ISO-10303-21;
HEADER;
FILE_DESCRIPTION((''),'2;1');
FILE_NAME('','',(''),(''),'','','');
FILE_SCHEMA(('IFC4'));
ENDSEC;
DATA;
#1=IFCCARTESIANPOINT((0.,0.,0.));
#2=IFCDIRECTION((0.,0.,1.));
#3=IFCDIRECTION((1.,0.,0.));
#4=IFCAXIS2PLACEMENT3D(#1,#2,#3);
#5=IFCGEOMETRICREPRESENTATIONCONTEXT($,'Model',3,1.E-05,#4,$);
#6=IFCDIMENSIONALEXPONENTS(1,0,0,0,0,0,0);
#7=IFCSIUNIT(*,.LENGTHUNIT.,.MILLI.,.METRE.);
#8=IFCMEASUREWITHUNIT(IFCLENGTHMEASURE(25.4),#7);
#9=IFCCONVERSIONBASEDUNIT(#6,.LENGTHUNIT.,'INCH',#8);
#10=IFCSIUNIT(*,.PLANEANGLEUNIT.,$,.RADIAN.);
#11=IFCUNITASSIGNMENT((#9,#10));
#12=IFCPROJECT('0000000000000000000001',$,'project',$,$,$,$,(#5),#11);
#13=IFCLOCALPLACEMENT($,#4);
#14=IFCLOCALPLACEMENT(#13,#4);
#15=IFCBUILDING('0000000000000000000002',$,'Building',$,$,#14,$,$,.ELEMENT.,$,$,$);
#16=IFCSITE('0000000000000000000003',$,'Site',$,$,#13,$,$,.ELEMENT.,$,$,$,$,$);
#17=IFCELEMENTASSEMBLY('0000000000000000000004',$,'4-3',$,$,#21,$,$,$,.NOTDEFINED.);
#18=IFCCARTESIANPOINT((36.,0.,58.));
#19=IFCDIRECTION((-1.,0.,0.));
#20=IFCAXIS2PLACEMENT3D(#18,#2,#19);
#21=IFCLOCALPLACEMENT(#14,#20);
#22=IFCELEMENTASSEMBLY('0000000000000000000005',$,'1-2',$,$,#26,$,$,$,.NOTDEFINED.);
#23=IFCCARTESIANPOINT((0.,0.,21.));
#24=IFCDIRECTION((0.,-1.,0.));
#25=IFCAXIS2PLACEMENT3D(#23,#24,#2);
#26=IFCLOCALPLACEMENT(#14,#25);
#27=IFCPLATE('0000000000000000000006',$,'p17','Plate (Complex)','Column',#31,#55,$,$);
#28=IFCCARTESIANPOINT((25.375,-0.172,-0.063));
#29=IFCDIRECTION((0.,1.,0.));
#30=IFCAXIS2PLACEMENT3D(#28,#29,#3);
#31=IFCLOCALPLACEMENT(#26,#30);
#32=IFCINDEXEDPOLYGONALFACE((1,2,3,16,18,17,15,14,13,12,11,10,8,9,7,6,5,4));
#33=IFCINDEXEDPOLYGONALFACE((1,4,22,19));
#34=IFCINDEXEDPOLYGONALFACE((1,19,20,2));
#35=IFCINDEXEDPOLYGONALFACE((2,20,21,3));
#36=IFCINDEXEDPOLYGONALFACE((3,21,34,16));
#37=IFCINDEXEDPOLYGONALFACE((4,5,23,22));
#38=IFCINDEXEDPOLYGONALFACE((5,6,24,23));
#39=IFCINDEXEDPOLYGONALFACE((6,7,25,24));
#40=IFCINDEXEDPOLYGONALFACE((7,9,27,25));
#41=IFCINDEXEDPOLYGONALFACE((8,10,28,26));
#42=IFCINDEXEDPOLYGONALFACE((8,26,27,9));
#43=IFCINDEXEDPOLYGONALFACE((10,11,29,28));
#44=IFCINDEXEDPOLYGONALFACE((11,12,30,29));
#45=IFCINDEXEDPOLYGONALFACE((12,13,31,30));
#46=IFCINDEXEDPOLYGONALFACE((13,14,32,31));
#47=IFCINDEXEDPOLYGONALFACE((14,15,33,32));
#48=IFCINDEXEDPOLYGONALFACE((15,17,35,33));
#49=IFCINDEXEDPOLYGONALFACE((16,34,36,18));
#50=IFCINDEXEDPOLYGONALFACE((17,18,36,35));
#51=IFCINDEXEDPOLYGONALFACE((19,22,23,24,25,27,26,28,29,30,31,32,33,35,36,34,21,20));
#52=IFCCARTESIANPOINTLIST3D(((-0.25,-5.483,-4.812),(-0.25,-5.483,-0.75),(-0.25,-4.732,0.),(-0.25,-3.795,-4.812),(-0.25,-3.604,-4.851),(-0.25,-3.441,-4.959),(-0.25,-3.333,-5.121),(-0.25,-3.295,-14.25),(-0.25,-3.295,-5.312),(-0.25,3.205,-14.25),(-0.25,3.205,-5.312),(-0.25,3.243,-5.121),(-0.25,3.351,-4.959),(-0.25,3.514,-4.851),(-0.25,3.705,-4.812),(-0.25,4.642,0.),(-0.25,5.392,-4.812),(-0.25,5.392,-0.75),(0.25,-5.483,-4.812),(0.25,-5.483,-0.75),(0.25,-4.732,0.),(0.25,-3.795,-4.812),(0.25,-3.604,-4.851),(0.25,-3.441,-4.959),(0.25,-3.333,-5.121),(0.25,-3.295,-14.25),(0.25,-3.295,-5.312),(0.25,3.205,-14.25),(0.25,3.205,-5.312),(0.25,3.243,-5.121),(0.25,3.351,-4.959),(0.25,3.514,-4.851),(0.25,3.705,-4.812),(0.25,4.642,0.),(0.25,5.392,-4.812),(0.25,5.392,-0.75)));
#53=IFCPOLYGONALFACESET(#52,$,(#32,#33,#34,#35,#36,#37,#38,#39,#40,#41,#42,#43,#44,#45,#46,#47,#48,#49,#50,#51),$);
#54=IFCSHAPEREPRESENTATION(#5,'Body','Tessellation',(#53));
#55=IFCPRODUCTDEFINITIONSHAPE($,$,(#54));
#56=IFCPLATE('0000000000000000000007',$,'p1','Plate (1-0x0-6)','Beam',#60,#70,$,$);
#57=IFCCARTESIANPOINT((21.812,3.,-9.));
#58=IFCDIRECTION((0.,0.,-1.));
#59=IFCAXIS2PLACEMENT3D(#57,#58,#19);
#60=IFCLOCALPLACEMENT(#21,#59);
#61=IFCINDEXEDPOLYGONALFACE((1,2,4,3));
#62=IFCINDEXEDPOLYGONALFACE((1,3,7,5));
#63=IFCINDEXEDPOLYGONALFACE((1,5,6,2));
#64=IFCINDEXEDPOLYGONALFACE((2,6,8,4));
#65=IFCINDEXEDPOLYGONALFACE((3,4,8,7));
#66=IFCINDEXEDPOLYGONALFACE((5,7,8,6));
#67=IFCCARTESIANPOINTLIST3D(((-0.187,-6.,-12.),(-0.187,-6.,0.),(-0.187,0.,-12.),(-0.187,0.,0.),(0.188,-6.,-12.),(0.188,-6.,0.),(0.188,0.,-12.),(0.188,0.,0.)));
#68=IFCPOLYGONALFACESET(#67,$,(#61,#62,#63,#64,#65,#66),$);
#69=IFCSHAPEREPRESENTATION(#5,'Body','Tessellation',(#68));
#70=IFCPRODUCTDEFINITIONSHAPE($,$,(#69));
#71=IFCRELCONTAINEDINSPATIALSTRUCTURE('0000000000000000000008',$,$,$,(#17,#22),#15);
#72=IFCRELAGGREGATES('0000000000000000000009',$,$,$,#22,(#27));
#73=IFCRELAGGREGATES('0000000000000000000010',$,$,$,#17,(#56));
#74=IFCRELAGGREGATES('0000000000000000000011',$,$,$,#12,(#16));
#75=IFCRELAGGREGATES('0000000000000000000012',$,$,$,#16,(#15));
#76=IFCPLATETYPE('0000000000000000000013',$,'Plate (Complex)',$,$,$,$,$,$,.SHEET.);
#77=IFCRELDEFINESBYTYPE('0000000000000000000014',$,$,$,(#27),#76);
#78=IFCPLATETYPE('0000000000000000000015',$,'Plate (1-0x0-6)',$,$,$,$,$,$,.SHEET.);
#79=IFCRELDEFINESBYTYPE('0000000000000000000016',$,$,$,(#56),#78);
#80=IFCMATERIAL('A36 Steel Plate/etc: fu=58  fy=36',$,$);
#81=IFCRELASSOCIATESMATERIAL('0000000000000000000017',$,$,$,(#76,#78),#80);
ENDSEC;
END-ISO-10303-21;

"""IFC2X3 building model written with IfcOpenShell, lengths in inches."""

from ifc_helpers import new_model, entity, si_unit, converted_unit, frame, origin_with_axes, place, context, project, spatial, polyline, outline, extrude, source, transform, mapped, material, type_object, type_shapes, element, aggregate, save


model = new_model("IFC2X3")

# Units and contexts
model_context = context("Model", 3, precision=1e-05, world=origin_with_axes())
ifc_project = project(units=[converted_unit("LENGTHUNIT", "INCH", entity("IfcLengthMeasure", 25.4), si_unit("LENGTHUNIT", "METRE", prefix="MILLI"), dimensions=[1, 0, 0, 0, 0, 0, 0]), si_unit("PLANEANGLEUNIT", "RADIAN")], contexts=[model_context])

# Site, building
site_placement = place(None, origin_with_axes())
site = spatial("IfcSite", under=ifc_project, at=site_placement, Name="Site", CompositionType="ELEMENT")
building_placement = place(site_placement, origin_with_axes())
building = spatial("IfcBuilding", under=site, at=building_placement, Name="Building", CompositionType="ELEMENT")

# Element assembly
assembly_1_placement = place(building_placement, frame((36.0, 0.0, 58.0), z_axis=(0.0, 0.0, 1.0), x_axis=(-1.0, 0.0, 0.0)))
assembly_1 = element("IfcElementAssembly", 1, at=assembly_1_placement, inside=building, Name="4-3", PredefinedType="NOTDEFINED")

# Element assembly, plate
assembly_2_placement = place(building_placement, frame((0.0, 0.0, 21.0), z_axis=(0.0, -1.0, 0.0), x_axis=(0.0, 0.0, 1.0)))
assembly_2 = element("IfcElementAssembly", 2, at=assembly_2_placement, inside=building, Name="1-2", PredefinedType="NOTDEFINED")
ifc_material_1 = material(Name="A36 Steel Plate/etc: fu=58  fy=36")
plate_type_1 = type_object("IfcPlateType", Name="Plate (Complex)", PredefinedType="SHEET", material=ifc_material_1)
shared_shape_1 = source(origin_with_axes(), model_context, "Body", "SweptSolid", [
    extrude(outline(polyline([(5.393, -4.812), (3.705, -4.812), (3.514, -4.851), (3.351, -4.959), (3.243, -5.121), (3.205, -5.312), (3.205, -14.25), (-3.295, -14.25), (-3.295, -5.312), (-3.333, -5.121), (-3.441, -4.959), (-3.604, -4.851), (-3.795, -4.812), (-5.482, -4.812), (-5.482, -0.75), (-4.732, 0.0), (4.643, 0.0), (5.393, -0.75), (5.393, -4.812)])), frame((-0.25, 0.0, 0.0), z_axis=(1.0, 0.0, 0.0), x_axis=(0.0, 1.0, 0.0)), (0.0, 0.0, 1.0), 0.5),
])
type_shapes(plate_type_1, [shared_shape_1])
plate_1_placement = place(assembly_2_placement, frame((25.375, -0.172, -0.063), z_axis=(0.0, 1.0, 0.0), x_axis=(1.0, 0.0, 0.0)))
plate_1 = element("IfcPlate", 3, at=plate_1_placement, type_object=plate_type_1, Name="p17", Description="Plate (Complex)", ObjectType="Column", context=model_context, shape_type="MappedRepresentation", body=[
    mapped(shared_shape_1, transform((0.0, 0.0, 0.0), scale=1.0)),
])
aggregate(assembly_2, [plate_1])

# Plate
plate_type_2 = type_object("IfcPlateType", Name="Plate (1-0x0-6)", PredefinedType="SHEET", material=ifc_material_1)
shared_shape_2 = source(origin_with_axes(), model_context, "Body", "SweptSolid", [
    extrude(outline(polyline([(0.0, -12.0), (-6.0, -12.0), (-6.0, 0.0), (0.0, 0.0), (0.0, -12.0)])), frame((-0.188, 0.0, 0.0), z_axis=(1.0, 0.0, 0.0), x_axis=(0.0, 1.0, 0.0)), (0.0, 0.0, 1.0), 0.375),
])
type_shapes(plate_type_2, [shared_shape_2])
plate_2_placement = place(assembly_1_placement, frame((21.812, 3.0, -9.0), z_axis=(0.0, 0.0, -1.0), x_axis=(-1.0, 0.0, 0.0)))
plate_2 = element("IfcPlate", 4, at=plate_2_placement, type_object=plate_type_2, Name="p1", Description="Plate (1-0x0-6)", ObjectType="Beam", context=model_context, shape_type="MappedRepresentation", body=[
    mapped(shared_shape_2, transform((0.0, 0.0, 0.0), scale=1.0)),
])
aggregate(assembly_1, [plate_2])

save(model, "model.ifc")
